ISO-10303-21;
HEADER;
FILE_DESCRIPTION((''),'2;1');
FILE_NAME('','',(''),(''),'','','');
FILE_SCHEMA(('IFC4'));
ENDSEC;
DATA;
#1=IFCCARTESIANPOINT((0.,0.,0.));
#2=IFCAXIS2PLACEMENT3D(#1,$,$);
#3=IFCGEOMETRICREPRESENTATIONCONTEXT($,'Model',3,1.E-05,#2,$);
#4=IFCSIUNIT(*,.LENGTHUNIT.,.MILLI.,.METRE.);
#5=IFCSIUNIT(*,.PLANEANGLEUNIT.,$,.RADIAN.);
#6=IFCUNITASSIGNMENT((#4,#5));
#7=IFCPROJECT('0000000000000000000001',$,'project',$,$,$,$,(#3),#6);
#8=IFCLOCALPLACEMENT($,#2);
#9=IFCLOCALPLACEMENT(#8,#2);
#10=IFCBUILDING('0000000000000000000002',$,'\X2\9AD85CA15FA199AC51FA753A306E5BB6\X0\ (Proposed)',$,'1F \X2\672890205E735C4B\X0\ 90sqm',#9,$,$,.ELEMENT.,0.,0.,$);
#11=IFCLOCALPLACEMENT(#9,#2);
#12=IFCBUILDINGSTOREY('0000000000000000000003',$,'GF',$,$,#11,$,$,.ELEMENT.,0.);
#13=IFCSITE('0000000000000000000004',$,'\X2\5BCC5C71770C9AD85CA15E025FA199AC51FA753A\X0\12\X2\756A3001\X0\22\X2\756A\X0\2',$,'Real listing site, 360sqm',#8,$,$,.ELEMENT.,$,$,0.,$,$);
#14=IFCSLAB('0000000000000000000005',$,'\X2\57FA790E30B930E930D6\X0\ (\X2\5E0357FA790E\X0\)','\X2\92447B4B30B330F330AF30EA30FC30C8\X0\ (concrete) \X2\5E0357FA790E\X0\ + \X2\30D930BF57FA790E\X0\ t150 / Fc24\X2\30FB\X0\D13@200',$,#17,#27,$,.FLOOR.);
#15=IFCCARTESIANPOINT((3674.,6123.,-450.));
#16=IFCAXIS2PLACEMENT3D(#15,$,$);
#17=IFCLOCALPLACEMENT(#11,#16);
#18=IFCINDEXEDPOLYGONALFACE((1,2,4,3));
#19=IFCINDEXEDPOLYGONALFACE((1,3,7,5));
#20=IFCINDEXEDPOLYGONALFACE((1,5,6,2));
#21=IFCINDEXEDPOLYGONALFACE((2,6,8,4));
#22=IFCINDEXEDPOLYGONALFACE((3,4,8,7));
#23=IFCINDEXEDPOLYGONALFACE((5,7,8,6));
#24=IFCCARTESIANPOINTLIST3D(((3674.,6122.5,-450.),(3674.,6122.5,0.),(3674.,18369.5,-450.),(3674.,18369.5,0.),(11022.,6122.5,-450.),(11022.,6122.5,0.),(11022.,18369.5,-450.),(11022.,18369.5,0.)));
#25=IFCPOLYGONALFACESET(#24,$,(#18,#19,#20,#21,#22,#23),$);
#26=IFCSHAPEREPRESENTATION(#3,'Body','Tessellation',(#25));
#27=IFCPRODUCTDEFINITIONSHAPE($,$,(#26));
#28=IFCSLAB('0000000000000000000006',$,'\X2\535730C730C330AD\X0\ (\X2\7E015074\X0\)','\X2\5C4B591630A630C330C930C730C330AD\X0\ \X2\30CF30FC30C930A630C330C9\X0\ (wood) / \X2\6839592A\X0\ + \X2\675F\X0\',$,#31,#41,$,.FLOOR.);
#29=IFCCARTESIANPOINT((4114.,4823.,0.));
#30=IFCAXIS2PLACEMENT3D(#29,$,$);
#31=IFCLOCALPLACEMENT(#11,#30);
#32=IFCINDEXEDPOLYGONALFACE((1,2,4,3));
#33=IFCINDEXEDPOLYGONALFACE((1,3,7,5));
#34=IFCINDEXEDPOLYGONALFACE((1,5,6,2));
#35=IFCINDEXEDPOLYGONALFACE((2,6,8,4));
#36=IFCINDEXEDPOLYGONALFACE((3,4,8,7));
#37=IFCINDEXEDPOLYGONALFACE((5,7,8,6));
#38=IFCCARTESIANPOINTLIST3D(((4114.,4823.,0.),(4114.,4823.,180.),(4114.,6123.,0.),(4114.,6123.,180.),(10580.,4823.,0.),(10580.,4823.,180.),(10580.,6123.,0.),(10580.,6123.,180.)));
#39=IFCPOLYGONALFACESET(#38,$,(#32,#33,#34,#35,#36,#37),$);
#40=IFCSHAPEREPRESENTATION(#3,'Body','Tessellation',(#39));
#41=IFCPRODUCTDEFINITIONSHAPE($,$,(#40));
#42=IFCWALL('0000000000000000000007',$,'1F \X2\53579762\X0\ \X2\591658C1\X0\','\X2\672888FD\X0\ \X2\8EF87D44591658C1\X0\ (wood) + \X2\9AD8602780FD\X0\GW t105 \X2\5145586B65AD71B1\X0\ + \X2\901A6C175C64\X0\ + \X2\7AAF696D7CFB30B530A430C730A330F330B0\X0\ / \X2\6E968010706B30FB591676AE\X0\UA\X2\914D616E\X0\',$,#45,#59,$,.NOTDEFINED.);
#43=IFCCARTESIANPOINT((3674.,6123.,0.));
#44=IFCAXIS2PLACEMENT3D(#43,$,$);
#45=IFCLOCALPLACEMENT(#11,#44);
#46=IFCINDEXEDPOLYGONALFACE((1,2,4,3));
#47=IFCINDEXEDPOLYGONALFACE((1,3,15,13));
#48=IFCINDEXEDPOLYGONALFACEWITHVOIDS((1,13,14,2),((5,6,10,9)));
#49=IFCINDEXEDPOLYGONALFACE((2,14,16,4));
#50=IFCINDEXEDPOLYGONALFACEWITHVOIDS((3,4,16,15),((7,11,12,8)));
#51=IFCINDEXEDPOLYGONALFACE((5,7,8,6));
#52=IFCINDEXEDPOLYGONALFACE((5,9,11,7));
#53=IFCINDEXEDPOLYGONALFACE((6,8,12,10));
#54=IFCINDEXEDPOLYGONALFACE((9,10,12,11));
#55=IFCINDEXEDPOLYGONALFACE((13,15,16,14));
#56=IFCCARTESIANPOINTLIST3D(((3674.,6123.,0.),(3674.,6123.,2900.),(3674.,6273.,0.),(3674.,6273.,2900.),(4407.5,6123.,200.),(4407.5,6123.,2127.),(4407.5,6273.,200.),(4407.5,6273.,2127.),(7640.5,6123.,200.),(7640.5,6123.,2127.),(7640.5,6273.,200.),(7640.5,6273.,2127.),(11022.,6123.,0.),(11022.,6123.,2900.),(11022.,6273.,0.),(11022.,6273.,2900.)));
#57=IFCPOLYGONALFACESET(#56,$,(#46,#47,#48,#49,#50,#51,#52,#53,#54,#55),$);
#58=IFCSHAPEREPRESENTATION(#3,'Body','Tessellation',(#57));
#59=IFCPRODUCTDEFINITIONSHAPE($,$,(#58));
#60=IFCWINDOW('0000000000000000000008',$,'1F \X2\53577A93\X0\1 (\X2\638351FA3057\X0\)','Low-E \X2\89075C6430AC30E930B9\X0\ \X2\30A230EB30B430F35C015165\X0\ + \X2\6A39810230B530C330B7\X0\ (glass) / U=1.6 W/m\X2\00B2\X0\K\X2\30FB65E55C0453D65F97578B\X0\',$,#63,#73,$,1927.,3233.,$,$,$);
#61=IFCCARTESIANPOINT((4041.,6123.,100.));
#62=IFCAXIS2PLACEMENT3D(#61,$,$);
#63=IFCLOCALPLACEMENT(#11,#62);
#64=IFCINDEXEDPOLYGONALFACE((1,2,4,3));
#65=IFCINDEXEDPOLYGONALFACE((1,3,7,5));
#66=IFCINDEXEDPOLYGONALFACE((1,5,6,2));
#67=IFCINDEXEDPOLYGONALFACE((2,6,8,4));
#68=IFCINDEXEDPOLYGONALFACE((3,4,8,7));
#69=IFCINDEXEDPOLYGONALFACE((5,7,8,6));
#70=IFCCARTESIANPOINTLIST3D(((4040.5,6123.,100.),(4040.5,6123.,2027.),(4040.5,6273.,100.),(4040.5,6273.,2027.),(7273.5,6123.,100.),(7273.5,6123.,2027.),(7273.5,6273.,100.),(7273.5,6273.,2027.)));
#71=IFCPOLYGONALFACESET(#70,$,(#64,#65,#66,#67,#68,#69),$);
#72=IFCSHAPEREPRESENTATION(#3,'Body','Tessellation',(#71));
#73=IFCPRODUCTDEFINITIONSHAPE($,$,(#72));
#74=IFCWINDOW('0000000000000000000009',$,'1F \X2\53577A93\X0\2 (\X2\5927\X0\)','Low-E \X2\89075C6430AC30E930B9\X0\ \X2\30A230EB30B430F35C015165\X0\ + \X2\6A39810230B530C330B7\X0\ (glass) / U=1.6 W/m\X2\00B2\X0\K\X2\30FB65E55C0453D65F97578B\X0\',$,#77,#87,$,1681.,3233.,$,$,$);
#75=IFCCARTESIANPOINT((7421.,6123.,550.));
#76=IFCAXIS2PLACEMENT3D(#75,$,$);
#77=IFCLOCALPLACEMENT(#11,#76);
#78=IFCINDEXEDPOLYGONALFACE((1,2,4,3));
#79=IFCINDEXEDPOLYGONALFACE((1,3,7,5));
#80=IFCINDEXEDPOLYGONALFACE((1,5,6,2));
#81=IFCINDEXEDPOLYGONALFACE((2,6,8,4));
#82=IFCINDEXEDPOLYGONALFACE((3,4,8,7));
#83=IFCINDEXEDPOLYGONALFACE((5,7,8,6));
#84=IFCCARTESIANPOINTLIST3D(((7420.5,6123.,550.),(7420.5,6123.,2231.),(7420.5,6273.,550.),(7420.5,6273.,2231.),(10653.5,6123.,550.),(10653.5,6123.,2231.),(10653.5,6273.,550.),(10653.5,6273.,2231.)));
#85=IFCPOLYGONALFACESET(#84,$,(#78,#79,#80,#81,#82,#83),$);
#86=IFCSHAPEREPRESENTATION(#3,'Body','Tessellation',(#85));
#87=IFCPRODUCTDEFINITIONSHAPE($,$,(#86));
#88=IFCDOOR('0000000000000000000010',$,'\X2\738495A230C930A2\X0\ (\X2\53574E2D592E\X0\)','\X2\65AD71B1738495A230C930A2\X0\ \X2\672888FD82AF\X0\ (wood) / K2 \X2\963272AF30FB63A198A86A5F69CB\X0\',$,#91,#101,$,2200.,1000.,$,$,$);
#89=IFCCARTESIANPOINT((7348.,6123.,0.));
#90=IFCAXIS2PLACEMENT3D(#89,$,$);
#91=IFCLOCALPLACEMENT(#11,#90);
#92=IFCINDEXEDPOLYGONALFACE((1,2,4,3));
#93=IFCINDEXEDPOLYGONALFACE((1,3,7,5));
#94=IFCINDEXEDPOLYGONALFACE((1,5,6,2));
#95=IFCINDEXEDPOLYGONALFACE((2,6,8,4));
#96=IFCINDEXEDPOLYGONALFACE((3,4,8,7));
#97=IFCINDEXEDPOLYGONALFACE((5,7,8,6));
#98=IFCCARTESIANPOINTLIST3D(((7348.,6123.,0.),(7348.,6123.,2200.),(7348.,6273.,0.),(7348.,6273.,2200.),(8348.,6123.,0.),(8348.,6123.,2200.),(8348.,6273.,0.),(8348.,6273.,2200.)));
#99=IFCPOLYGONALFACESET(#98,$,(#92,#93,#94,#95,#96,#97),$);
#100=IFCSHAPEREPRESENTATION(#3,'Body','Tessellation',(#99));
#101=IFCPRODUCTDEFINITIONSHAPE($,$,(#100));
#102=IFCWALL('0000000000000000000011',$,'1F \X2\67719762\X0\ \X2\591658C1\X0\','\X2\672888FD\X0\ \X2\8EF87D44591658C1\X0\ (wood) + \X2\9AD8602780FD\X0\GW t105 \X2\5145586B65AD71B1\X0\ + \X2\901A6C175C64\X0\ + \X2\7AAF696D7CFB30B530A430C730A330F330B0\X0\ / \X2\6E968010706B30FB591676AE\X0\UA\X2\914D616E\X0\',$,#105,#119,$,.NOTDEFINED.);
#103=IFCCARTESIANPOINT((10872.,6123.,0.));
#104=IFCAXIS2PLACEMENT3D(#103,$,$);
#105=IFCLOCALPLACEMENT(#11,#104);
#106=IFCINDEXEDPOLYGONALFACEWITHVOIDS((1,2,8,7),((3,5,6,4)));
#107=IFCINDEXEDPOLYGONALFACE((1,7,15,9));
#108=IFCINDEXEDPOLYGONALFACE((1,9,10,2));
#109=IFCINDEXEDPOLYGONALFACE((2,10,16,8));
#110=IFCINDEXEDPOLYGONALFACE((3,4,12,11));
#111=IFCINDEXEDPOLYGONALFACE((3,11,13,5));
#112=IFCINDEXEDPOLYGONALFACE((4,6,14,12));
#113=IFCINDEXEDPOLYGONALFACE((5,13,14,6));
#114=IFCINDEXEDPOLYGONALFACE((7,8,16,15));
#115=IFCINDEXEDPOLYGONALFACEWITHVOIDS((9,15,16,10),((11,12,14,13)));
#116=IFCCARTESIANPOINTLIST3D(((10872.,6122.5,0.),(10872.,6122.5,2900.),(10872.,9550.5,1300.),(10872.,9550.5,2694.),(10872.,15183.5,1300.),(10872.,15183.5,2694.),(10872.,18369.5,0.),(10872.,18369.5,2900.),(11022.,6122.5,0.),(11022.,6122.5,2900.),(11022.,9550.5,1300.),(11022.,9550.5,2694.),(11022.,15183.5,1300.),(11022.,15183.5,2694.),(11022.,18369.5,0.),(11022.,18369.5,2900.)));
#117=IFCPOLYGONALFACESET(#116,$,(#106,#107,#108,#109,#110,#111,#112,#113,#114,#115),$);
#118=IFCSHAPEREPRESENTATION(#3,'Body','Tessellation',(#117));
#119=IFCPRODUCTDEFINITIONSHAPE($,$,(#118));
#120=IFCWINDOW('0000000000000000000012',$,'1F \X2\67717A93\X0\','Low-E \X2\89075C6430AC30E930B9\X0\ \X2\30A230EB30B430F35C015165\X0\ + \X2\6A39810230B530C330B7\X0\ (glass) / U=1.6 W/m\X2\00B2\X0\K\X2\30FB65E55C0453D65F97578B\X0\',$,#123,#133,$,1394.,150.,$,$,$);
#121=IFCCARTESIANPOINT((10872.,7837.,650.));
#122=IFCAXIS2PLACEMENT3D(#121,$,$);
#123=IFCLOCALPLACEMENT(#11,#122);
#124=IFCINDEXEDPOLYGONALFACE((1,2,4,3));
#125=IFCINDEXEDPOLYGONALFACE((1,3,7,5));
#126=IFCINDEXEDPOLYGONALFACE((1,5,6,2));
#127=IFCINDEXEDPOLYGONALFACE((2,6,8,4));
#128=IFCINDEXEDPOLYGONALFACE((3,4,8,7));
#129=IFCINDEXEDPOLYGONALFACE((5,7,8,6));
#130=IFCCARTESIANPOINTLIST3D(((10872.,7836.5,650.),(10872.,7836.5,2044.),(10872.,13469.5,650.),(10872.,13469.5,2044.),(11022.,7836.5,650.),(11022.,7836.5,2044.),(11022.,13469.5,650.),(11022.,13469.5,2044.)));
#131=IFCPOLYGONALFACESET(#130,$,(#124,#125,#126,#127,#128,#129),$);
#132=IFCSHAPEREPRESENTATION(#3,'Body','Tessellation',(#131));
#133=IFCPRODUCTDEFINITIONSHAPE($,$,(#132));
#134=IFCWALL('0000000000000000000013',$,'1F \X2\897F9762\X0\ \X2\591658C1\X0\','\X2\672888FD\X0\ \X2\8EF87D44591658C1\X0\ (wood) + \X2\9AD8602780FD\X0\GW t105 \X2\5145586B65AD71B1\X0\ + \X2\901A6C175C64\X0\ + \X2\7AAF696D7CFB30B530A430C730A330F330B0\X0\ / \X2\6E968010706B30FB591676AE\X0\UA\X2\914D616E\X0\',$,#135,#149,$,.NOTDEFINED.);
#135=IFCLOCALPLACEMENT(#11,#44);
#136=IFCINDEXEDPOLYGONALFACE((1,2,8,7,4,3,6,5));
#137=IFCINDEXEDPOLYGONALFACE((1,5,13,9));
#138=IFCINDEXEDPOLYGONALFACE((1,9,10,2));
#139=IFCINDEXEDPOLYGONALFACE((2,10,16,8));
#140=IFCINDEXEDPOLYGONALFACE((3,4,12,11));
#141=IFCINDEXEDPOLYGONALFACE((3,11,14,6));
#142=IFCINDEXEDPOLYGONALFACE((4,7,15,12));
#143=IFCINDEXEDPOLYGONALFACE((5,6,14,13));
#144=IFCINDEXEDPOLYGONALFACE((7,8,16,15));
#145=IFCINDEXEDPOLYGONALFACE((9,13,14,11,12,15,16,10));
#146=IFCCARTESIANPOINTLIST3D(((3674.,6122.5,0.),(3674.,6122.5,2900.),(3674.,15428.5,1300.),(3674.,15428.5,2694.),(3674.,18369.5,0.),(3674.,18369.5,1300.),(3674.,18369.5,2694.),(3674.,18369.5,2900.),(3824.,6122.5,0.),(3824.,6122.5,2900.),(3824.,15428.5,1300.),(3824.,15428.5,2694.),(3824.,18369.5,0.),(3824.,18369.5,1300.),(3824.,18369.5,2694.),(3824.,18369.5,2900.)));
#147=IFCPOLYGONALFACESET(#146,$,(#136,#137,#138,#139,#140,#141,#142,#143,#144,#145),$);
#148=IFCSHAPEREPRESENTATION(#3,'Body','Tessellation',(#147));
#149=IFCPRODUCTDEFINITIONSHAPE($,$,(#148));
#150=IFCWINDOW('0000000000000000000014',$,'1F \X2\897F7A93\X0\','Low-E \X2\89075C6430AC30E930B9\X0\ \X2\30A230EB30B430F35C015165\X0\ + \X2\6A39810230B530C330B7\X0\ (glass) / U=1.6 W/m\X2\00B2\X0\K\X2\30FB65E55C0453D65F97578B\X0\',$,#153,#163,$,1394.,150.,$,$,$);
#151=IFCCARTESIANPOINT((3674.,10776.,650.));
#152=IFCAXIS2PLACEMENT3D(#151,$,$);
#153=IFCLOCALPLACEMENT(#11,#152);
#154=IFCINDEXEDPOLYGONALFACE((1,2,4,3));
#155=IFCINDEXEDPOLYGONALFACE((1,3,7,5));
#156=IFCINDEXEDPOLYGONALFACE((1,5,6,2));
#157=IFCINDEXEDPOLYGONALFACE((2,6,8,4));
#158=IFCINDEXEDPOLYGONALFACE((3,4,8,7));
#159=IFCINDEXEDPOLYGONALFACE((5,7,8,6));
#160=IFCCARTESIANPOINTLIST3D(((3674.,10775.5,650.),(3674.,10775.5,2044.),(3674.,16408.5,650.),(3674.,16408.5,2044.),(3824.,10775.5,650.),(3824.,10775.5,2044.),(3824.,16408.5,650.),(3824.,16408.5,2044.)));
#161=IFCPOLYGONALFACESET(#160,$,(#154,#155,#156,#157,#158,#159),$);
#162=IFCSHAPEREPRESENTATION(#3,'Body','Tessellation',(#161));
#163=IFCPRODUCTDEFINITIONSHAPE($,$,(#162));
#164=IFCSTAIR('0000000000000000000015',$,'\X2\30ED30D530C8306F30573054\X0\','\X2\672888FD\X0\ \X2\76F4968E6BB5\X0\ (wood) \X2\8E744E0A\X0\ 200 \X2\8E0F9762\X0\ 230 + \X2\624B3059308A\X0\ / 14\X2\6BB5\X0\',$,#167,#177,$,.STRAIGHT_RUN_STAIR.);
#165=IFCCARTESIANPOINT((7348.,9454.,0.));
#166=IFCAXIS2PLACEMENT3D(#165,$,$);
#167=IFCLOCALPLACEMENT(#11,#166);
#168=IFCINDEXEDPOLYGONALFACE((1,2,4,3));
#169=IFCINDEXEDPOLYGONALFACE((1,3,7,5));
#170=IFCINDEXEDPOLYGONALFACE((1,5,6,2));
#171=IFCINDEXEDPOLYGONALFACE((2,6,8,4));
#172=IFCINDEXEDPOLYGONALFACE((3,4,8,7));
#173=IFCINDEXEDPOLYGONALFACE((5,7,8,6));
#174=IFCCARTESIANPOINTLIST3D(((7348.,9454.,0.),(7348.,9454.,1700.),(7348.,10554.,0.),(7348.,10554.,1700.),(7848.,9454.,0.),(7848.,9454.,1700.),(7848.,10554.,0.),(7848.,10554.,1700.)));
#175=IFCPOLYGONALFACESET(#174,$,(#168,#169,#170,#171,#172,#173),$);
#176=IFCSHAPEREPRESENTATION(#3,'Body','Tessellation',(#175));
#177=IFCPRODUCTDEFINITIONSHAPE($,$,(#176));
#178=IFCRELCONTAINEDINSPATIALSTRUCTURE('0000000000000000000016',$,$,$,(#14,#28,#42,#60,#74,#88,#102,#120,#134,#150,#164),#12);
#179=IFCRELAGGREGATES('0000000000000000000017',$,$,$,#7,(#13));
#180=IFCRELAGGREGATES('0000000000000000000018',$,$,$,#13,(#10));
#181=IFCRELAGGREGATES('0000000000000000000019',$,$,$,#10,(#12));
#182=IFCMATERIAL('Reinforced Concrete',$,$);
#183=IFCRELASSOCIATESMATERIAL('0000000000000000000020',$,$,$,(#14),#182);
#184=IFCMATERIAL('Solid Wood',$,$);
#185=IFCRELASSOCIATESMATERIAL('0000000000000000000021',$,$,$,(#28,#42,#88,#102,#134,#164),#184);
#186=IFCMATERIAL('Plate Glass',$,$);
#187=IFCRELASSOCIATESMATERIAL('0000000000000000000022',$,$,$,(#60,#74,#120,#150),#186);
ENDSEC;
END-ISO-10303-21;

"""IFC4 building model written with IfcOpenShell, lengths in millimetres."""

from ifc_helpers import new_model, si_unit, frame, frame_2d, origin, place, context, project, spatial, rectangle, extrude, material, element, fill, save


model = new_model("IFC4")

# Units and contexts
model_context = context("Model", 3, precision=1e-05, world=origin())
ifc_project = project(units=[si_unit("LENGTHUNIT", "METRE", prefix="MILLI"), si_unit("PLANEANGLEUNIT", "RADIAN")], contexts=[model_context])

# Site, building, storey
site_placement = place(None, origin())
site = spatial("IfcSite", under=ifc_project, at=site_placement, Name="富山県高岡市御馬出町12番、22番2", ObjectType="Real listing site, 360sqm", CompositionType="ELEMENT", RefElevation=0.0)
building_placement = place(site_placement, origin())
building = spatial("IfcBuilding", under=site, at=building_placement, Name="高岡御馬出町の家 (Proposed)", ObjectType="1F 木造平屋 90sqm", CompositionType="ELEMENT", ElevationOfRefHeight=0.0, ElevationOfTerrain=0.0)
storey_placement = place(building_placement, origin())
storey = spatial("IfcBuildingStorey", under=building, at=storey_placement, Name="GF", CompositionType="ELEMENT", Elevation=0.0)

# Slabs
ifc_material_1 = material(Name="Reinforced Concrete")
slab_1_placement = place(storey_placement, frame((3674.0, 6123.0, -450.0)))
element("IfcSlab", 1, at=slab_1_placement, inside=storey, material=ifc_material_1, Name="基礎スラブ (布基礎)", Description="鉄筋コンクリート (concrete) 布基礎 + ベタ基礎 t150 / Fc24・D13@200", PredefinedType="FLOOR", context=model_context, shape_type="SweptSolid", body=[
    extrude(rectangle(XDim=7348.0, YDim=12247.0, at=frame_2d((3674.0, 6123.0))), frame((3674.0, 6123.0, -450.0)), (0.0, 0.0, 1.0), 450.0),
])
ifc_material_2 = material(Name="Solid Wood")
slab_2_placement = place(storey_placement, frame((4114.0, 4823.0, 0.0)))
element("IfcSlab", 2, at=slab_2_placement, inside=storey, material=ifc_material_2, Name="南デッキ (縁側)", Description="屋外ウッドデッキ ハードウッド (wood) / 根太 + 束", PredefinedType="FLOOR", context=model_context, shape_type="SweptSolid", body=[
    extrude(rectangle(XDim=6466.0, YDim=1300.0, at=frame_2d((3233.0, 650.0))), frame((4114.0, 4823.0, 0.0)), (0.0, 0.0, 1.0), 180.0),
])

# Wall, openings, windows, door
wall_1_placement = place(storey_placement, frame((3674.0, 6123.0, 0.0)))
wall_1 = element("IfcWall", 3, at=wall_1_placement, inside=storey, material=ifc_material_2, Name="1F 南面 外壁", Description="木製 軸組外壁 (wood) + 高性能GW t105 充填断熱 + 通気層 + 窯業系サイディング / 準耐火・外皮UA配慮", PredefinedType="NOTDEFINED", context=model_context, shape_type="SweptSolid", body=[
    extrude(rectangle(XDim=7348.0, YDim=150.0, at=frame_2d((3674.0, 75.0))), frame((3674.0, 6123.0, 0.0)), (0.0, 0.0, 1.0), 2900.0),
])
opening_1_placement = place(storey_placement, frame((4041.0, 6123.0, 100.0)))
opening_1 = element("IfcOpeningElement", 4, at=opening_1_placement, cuts=wall_1, PredefinedType="NOTDEFINED", context=model_context, shape_type="SweptSolid", body=[
    extrude(rectangle(XDim=3233.0, YDim=150.0, at=frame_2d((1616.0, 75.0))), frame((4041.0, 6123.0, 100.0)), (0.0, 0.0, 1.0), 1927.0),
])
opening_2_placement = place(storey_placement, frame((7421.0, 6123.0, 550.0)))
opening_2 = element("IfcOpeningElement", 5, at=opening_2_placement, cuts=wall_1, PredefinedType="NOTDEFINED", context=model_context, shape_type="SweptSolid", body=[
    extrude(rectangle(XDim=3233.0, YDim=150.0, at=frame_2d((1616.0, 75.0))), frame((7421.0, 6123.0, 550.0)), (0.0, 0.0, 1.0), 1681.0),
])
opening_3_placement = place(storey_placement, frame((7348.0, 6123.0, 0.0)))
opening_3 = element("IfcOpeningElement", 6, at=opening_3_placement, cuts=wall_1, PredefinedType="NOTDEFINED", context=model_context, shape_type="SweptSolid", body=[
    extrude(rectangle(XDim=1000.0, YDim=150.0, at=frame_2d((500.0, 75.0))), frame((7348.0, 6123.0, 0.0)), (0.0, 0.0, 1.0), 2200.0),
])
ifc_material_3 = material(Name="Plate Glass")
window_1_placement = place(storey_placement, frame((4041.0, 6123.0, 100.0)))
window_1 = element("IfcWindow", 7, at=window_1_placement, inside=storey, material=ifc_material_3, Name="1F 南窓1 (掃出し)", Description="Low-E 複層ガラス アルゴン封入 + 樹脂サッシ (glass) / U=1.6 W/m²K・日射取得型", OverallHeight=1927.0, OverallWidth=3233.0, context=model_context, shape_type="SweptSolid", body=[
    extrude(rectangle(XDim=3233.0, YDim=150.0, at=frame_2d((1616.0, 75.0))), frame((4041.0, 6123.0, 100.0)), (0.0, 0.0, 1.0), 1927.0),
])
fill(opening_1, window_1)
window_2_placement = place(storey_placement, frame((7421.0, 6123.0, 550.0)))
window_2 = element("IfcWindow", 8, at=window_2_placement, inside=storey, material=ifc_material_3, Name="1F 南窓2 (大)", Description="Low-E 複層ガラス アルゴン封入 + 樹脂サッシ (glass) / U=1.6 W/m²K・日射取得型", OverallHeight=1681.0, OverallWidth=3233.0, context=model_context, shape_type="SweptSolid", body=[
    extrude(rectangle(XDim=3233.0, YDim=150.0, at=frame_2d((1616.0, 75.0))), frame((7421.0, 6123.0, 550.0)), (0.0, 0.0, 1.0), 1681.0),
])
fill(opening_2, window_2)
door_placement = place(storey_placement, frame((7348.0, 6123.0, 0.0)))
door = element("IfcDoor", 9, at=door_placement, inside=storey, material=ifc_material_2, Name="玄関ドア (南中央)", Description="断熱玄関ドア 木製芯 (wood) / K2 防犯・採風機構", OverallHeight=2200.0, OverallWidth=1000.0, context=model_context, shape_type="SweptSolid", body=[
    extrude(rectangle(XDim=1000.0, YDim=150.0, at=frame_2d((500.0, 75.0))), frame((7348.0, 6123.0, 0.0)), (0.0, 0.0, 1.0), 2200.0),
])
fill(opening_3, door)

# Walls, openings, windows
wall_2_placement = place(storey_placement, frame((10872.0, 6123.0, 0.0)))
wall_2 = element("IfcWall", 10, at=wall_2_placement, inside=storey, material=ifc_material_2, Name="1F 東面 外壁", Description="木製 軸組外壁 (wood) + 高性能GW t105 充填断熱 + 通気層 + 窯業系サイディング / 準耐火・外皮UA配慮", PredefinedType="NOTDEFINED", context=model_context, shape_type="SweptSolid", body=[
    extrude(rectangle(XDim=150.0, YDim=12247.0, at=frame_2d((75.0, 6123.0))), frame((10872.0, 6123.0, 0.0)), (0.0, 0.0, 1.0), 2900.0),
])
opening_4_placement = place(storey_placement, frame((10872.0, 7837.0, 650.0)))
opening_4 = element("IfcOpeningElement", 11, at=opening_4_placement, cuts=wall_2, PredefinedType="NOTDEFINED", context=model_context, shape_type="SweptSolid", body=[
    extrude(rectangle(XDim=150.0, YDim=5633.0, at=frame_2d((75.0, 2816.0))), frame((10872.0, 7837.0, 650.0)), (0.0, 0.0, 1.0), 1394.0),
])
window_3_placement = place(storey_placement, frame((10872.0, 7837.0, 650.0)))
window_3 = element("IfcWindow", 12, at=window_3_placement, inside=storey, material=ifc_material_3, Name="1F 東窓", Description="Low-E 複層ガラス アルゴン封入 + 樹脂サッシ (glass) / U=1.6 W/m²K・日射取得型", OverallHeight=1394.0, OverallWidth=150.0, context=model_context, shape_type="SweptSolid", body=[
    extrude(rectangle(XDim=150.0, YDim=5633.0, at=frame_2d((75.0, 2816.0))), frame((10872.0, 7837.0, 650.0)), (0.0, 0.0, 1.0), 1394.0),
])
fill(opening_4, window_3)
wall_3_placement = place(storey_placement, frame((3674.0, 6123.0, 0.0)))
wall_3 = element("IfcWall", 13, at=wall_3_placement, inside=storey, material=ifc_material_2, Name="1F 西面 外壁", Description="木製 軸組外壁 (wood) + 高性能GW t105 充填断熱 + 通気層 + 窯業系サイディング / 準耐火・外皮UA配慮", PredefinedType="NOTDEFINED", context=model_context, shape_type="SweptSolid", body=[
    extrude(rectangle(XDim=150.0, YDim=12247.0, at=frame_2d((75.0, 6123.0))), frame((3674.0, 6123.0, 0.0)), (0.0, 0.0, 1.0), 2900.0),
])
opening_5_placement = place(storey_placement, frame((3674.0, 10776.0, 650.0)))
opening_5 = element("IfcOpeningElement", 14, at=opening_5_placement, cuts=wall_3, PredefinedType="NOTDEFINED", context=model_context, shape_type="SweptSolid", body=[
    extrude(rectangle(XDim=150.0, YDim=5633.0, at=frame_2d((75.0, 2816.0))), frame((3674.0, 10776.0, 650.0)), (0.0, 0.0, 1.0), 1394.0),
])
window_4_placement = place(storey_placement, frame((3674.0, 10776.0, 650.0)))
window_4 = element("IfcWindow", 15, at=window_4_placement, inside=storey, material=ifc_material_3, Name="1F 西窓", Description="Low-E 複層ガラス アルゴン封入 + 樹脂サッシ (glass) / U=1.6 W/m²K・日射取得型", OverallHeight=1394.0, OverallWidth=150.0, context=model_context, shape_type="SweptSolid", body=[
    extrude(rectangle(XDim=150.0, YDim=5633.0, at=frame_2d((75.0, 2816.0))), frame((3674.0, 10776.0, 650.0)), (0.0, 0.0, 1.0), 1394.0),
])
fill(opening_5, window_4)

# Stair
stair_placement = place(storey_placement, frame((7348.0, 9454.0, 0.0)))
element("IfcStair", 16, at=stair_placement, inside=storey, material=ifc_material_2, Name="ロフトはしご", Description="木製 直階段 (wood) 蹴上 200 踏面 230 + 手すり / 14段", PredefinedType="STRAIGHT_RUN_STAIR", context=model_context, shape_type="SweptSolid", body=[
    extrude(rectangle(XDim=500.0, YDim=1100.0, at=frame_2d((250.0, 550.0))), frame((7348.0, 9454.0, 0.0)), (0.0, 0.0, 1.0), 1700.0),
])

save(model, "model.ifc")
